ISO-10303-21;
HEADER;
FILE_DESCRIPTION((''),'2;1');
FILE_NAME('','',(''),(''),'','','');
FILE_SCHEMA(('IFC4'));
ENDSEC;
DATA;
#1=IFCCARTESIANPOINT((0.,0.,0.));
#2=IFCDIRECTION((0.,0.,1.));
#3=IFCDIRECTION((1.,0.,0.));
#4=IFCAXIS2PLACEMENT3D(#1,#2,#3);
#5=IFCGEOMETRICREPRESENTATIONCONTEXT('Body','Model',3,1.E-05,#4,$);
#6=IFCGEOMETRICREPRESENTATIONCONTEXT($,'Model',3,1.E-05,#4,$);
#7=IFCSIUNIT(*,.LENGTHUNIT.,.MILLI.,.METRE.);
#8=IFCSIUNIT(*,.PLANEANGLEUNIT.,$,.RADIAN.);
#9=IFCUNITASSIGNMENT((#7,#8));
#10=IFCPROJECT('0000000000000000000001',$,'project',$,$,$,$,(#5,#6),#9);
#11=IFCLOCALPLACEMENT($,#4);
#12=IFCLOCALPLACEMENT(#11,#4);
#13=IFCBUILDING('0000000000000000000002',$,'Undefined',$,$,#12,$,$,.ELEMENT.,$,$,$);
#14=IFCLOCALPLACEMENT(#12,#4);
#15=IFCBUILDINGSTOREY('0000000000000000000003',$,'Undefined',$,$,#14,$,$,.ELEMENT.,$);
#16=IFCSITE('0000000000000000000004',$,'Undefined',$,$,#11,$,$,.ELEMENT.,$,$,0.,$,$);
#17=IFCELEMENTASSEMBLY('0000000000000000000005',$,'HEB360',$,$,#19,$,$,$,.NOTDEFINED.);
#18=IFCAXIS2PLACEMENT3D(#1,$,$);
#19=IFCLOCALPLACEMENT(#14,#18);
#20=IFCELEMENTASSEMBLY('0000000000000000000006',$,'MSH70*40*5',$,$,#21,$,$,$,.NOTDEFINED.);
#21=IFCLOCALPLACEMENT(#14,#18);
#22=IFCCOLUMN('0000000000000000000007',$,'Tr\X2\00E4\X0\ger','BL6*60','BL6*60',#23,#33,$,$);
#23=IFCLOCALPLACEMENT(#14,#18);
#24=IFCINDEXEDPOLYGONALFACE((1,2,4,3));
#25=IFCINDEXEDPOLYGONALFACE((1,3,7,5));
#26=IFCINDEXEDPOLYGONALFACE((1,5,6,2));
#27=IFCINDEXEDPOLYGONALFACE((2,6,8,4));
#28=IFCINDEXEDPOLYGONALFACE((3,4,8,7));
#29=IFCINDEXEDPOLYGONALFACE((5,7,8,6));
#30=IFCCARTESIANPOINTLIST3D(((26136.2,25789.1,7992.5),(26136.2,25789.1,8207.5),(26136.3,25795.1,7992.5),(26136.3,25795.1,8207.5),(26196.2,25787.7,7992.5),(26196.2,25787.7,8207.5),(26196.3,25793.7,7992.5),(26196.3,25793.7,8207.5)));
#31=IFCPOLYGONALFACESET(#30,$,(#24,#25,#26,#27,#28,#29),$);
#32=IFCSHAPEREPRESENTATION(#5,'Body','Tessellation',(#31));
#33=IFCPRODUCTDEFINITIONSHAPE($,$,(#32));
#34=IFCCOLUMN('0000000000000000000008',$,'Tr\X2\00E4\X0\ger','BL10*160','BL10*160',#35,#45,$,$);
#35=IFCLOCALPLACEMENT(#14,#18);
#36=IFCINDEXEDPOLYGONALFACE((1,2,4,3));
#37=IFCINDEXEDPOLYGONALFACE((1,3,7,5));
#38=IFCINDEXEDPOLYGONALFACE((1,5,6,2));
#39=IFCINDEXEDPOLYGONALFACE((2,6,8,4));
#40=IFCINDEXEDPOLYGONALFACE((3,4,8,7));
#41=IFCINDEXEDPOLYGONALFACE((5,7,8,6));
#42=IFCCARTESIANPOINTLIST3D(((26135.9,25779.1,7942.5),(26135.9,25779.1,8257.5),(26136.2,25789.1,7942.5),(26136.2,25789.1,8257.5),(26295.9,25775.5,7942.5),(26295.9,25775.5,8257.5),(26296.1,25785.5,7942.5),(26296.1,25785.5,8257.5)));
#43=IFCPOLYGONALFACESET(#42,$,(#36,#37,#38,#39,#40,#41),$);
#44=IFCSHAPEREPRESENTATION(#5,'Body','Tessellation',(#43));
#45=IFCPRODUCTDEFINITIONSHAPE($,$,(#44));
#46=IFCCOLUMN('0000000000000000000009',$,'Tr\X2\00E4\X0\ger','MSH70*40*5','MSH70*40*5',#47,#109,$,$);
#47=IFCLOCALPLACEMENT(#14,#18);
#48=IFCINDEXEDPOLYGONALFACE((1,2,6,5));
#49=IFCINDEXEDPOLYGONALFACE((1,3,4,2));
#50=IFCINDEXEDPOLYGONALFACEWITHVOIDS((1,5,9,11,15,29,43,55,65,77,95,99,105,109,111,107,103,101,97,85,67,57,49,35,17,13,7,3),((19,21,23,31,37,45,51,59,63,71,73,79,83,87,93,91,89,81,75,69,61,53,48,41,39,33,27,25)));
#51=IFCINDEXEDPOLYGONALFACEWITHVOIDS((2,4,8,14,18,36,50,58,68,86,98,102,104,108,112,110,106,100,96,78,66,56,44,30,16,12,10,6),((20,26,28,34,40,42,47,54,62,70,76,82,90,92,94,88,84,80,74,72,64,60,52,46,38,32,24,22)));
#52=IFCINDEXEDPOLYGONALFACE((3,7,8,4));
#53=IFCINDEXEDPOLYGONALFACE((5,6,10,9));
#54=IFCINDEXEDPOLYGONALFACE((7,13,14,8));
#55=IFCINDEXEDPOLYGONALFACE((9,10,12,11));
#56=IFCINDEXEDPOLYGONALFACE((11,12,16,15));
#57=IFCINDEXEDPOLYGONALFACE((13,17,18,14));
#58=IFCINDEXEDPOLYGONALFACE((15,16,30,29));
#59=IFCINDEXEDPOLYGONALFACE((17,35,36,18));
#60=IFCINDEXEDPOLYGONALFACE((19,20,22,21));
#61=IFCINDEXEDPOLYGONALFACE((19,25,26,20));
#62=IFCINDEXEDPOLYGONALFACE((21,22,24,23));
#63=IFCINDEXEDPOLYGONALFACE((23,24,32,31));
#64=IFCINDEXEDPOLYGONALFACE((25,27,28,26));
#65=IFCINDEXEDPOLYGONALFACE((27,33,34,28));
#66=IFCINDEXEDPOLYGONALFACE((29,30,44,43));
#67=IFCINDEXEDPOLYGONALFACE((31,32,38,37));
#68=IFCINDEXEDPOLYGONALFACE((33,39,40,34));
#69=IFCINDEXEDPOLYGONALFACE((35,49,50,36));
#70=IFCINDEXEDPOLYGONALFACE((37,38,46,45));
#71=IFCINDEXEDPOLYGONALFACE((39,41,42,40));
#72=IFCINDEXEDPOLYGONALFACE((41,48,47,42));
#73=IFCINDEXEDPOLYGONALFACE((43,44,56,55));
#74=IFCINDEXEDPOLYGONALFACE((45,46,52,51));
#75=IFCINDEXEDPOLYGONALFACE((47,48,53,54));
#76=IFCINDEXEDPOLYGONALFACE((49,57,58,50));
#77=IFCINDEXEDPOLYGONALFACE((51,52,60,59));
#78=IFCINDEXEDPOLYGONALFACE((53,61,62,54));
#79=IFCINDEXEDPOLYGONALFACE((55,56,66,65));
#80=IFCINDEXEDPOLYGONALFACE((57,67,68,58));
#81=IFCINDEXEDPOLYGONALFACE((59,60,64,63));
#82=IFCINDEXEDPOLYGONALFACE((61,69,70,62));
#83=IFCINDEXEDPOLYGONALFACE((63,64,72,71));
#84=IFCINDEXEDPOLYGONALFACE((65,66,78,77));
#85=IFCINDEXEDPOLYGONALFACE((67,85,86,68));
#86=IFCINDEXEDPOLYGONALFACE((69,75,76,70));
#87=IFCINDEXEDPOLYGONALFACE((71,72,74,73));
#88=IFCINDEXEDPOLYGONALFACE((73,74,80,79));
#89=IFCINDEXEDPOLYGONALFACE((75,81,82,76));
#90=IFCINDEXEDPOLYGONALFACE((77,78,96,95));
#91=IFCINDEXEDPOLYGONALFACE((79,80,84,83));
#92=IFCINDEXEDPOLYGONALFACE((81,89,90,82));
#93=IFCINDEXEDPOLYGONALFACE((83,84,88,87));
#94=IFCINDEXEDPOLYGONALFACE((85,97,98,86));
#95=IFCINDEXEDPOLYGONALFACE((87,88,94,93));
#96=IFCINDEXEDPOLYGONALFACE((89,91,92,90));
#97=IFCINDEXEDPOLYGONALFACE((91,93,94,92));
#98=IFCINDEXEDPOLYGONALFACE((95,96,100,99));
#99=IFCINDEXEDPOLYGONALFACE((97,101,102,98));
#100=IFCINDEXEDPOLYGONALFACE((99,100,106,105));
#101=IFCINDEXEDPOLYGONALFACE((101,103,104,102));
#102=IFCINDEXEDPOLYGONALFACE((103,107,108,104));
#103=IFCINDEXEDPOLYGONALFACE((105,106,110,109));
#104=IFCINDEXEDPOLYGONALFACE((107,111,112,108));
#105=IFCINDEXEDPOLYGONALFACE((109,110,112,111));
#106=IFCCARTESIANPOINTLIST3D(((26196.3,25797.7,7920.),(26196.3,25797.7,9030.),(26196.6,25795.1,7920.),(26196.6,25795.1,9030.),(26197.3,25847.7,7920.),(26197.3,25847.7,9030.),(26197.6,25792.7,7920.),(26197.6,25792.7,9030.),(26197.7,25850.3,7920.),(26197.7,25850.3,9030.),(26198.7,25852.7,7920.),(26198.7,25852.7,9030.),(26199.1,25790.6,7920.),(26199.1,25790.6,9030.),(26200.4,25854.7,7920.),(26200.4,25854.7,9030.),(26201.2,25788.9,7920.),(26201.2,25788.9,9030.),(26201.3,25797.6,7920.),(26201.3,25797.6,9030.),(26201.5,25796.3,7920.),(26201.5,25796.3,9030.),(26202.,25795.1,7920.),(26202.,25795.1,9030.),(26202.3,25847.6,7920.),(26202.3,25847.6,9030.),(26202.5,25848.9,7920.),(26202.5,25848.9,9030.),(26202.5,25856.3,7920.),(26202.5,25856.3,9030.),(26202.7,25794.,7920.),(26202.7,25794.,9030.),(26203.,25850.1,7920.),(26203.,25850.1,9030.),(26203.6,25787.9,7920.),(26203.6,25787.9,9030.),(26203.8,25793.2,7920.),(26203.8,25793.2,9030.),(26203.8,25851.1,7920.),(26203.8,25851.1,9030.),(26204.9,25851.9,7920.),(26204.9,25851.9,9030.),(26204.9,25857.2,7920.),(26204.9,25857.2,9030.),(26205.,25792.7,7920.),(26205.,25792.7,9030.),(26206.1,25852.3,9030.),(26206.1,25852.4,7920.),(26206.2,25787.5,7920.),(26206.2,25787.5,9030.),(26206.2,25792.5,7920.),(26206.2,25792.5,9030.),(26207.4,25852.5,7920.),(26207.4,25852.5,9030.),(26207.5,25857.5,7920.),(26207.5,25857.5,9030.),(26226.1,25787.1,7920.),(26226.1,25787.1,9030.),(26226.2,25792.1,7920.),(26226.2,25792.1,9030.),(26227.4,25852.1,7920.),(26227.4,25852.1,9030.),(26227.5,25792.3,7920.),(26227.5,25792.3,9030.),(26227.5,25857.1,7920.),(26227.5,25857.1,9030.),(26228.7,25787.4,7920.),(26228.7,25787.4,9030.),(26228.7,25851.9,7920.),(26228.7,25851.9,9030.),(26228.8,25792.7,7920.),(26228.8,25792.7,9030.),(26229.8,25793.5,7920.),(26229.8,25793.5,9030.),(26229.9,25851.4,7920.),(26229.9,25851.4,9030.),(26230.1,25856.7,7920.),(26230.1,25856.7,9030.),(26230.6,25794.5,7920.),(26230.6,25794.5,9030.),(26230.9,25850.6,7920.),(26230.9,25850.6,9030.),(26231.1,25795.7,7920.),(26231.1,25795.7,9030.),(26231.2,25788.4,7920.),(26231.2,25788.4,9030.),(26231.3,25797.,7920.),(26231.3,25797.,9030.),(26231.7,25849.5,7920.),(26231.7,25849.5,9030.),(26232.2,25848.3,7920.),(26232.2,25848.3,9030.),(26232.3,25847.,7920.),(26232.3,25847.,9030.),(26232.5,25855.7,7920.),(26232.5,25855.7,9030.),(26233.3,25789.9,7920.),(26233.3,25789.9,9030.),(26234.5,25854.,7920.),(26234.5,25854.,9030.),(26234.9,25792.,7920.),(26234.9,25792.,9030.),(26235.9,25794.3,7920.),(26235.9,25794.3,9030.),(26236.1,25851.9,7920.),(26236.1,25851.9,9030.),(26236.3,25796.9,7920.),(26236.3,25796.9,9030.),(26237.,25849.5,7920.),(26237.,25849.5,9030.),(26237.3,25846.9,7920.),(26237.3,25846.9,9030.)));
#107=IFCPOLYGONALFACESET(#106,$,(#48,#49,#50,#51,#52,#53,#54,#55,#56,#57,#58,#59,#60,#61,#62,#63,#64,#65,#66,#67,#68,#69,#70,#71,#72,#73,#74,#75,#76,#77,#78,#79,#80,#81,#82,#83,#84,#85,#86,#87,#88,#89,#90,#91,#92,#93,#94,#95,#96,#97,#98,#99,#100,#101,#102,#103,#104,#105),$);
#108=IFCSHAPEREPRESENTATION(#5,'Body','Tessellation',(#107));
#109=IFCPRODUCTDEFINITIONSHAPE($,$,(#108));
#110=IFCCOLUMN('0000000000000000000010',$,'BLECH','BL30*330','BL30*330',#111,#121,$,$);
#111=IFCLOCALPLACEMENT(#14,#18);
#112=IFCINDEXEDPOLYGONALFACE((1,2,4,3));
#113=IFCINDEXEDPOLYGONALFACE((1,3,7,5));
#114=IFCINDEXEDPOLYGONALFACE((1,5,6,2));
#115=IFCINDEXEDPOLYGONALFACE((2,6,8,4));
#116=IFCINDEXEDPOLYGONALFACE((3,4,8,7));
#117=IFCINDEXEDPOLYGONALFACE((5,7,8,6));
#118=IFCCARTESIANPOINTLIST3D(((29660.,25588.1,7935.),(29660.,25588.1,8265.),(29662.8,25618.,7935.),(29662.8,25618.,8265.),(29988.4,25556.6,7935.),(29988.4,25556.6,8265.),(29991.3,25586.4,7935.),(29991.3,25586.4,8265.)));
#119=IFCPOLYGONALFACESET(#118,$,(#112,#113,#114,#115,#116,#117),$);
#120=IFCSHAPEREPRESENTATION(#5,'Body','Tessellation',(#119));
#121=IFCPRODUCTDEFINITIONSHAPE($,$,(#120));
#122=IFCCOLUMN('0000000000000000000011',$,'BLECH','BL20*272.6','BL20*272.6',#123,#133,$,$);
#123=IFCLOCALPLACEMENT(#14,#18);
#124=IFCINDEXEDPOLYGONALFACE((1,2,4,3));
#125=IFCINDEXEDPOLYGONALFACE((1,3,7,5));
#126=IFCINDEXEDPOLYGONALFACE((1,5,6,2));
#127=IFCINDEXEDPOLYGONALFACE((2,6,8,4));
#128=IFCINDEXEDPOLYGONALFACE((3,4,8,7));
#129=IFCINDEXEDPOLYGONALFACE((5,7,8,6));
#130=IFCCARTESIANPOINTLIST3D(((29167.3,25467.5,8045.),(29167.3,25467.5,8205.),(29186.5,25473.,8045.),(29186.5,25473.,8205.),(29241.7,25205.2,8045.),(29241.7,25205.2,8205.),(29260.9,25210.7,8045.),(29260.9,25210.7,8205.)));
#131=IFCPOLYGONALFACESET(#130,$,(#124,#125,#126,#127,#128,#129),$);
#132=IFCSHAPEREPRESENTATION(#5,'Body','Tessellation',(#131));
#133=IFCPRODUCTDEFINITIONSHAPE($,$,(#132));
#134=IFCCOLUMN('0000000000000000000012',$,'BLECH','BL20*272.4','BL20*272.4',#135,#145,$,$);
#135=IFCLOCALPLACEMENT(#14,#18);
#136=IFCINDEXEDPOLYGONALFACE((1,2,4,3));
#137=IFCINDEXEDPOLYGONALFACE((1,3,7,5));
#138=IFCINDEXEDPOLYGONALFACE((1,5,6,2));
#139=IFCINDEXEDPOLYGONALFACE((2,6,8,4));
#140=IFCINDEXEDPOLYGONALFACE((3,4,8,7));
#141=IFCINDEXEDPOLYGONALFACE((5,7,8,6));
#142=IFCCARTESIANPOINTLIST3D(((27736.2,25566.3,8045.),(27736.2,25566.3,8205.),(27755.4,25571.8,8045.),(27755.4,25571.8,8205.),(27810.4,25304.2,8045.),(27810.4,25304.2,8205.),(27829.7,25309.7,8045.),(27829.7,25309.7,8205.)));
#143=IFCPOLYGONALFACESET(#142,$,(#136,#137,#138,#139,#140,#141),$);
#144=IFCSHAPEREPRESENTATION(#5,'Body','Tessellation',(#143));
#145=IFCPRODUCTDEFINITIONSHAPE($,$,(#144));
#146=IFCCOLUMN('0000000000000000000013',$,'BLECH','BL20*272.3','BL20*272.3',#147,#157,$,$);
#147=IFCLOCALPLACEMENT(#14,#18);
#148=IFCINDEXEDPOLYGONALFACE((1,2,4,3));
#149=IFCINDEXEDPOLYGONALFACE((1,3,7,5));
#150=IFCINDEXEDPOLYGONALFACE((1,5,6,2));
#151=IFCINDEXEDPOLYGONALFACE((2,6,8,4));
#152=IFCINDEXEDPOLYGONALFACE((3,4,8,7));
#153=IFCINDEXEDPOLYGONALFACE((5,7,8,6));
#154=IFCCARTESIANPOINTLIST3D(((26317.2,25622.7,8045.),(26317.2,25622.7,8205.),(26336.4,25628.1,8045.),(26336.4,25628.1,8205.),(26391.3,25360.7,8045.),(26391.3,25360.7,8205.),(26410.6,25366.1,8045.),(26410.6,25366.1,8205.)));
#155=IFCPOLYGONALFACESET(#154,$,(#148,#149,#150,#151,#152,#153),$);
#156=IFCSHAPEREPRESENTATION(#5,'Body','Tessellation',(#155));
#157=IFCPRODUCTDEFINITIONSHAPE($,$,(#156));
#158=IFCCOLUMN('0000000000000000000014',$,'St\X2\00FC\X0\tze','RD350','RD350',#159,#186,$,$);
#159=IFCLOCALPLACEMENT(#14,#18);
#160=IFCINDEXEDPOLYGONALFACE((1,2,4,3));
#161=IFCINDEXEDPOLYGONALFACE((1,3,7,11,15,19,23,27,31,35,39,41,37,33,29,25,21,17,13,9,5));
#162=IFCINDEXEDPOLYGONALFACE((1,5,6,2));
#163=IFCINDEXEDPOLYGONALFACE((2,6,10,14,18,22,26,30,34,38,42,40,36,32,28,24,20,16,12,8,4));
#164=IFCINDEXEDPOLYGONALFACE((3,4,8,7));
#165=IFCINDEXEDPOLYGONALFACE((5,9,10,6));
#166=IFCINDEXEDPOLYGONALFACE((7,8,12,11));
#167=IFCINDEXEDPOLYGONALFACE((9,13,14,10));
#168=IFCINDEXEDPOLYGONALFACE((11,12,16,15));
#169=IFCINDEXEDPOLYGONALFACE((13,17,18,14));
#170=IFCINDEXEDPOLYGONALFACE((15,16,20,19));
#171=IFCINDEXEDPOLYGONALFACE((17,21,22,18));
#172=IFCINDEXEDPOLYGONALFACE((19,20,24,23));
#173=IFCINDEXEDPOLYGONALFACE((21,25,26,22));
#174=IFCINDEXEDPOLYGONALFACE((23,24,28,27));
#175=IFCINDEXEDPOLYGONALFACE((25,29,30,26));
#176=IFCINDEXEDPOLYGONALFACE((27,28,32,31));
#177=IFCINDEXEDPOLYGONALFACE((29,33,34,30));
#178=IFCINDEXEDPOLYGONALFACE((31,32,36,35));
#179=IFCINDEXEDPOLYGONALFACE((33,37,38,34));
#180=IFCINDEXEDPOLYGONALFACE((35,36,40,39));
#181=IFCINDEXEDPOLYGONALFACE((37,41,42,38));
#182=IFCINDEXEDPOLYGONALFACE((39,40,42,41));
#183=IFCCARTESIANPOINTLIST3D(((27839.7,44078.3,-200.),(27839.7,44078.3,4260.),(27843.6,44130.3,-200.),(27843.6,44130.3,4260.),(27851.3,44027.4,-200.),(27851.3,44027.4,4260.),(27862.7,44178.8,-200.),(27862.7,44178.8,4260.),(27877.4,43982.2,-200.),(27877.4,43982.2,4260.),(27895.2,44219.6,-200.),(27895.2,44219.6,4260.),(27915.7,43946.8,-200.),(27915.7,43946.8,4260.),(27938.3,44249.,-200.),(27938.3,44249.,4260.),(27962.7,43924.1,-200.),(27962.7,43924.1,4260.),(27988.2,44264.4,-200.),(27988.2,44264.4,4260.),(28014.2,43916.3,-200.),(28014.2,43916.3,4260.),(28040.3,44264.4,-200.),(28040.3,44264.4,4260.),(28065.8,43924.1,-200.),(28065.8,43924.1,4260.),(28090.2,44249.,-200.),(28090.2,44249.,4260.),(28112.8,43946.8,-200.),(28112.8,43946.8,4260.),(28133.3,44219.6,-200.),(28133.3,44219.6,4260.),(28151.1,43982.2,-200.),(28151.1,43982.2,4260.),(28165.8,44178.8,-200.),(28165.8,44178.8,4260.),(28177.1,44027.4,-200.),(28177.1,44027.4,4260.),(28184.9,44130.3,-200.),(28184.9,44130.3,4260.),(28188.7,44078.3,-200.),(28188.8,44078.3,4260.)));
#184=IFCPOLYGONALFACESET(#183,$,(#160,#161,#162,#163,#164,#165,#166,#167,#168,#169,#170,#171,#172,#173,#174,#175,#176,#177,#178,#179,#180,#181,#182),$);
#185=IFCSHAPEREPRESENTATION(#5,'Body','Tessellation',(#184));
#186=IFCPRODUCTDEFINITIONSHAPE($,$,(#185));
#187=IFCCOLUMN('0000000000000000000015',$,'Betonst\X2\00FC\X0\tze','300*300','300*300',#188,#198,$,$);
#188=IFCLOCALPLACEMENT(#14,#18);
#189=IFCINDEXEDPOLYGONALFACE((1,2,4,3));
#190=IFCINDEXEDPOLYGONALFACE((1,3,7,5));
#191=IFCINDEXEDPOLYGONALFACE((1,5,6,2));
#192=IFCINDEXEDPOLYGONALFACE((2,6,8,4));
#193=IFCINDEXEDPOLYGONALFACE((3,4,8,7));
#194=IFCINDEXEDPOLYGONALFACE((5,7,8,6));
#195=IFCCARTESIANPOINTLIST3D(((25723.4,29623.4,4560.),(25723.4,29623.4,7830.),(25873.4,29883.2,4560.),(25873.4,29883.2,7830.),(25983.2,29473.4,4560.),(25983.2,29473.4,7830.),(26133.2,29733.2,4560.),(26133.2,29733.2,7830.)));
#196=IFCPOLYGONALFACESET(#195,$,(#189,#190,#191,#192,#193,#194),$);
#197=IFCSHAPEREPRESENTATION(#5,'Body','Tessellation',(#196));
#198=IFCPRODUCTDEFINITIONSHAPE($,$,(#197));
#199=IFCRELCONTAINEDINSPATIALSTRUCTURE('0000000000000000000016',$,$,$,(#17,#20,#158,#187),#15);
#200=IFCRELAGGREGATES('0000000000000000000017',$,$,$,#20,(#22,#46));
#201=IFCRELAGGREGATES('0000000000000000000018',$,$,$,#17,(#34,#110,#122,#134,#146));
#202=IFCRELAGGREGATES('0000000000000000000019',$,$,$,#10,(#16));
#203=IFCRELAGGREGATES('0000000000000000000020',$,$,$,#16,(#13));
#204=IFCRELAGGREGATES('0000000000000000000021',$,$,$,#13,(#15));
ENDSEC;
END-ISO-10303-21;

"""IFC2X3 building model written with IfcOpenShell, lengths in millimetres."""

from ifc_helpers import new_model, si_unit, frame, origin_with_axes, origin_2d_with_axis, place, context, project, spatial, rectangle, hollow_rectangle, circle, extrude, element, aggregate, save


model = new_model("IFC2X3")

# Units and contexts
model_context_1 = context("Model", 3, precision=1e-05, world=origin_with_axes(), identifier="Body")
model_context_2 = context("Model", 3, precision=1e-05, world=origin_with_axes())
ifc_project = project(units=[si_unit("LENGTHUNIT", "METRE", prefix="MILLI"), si_unit("PLANEANGLEUNIT", "RADIAN")], contexts=[model_context_1, model_context_2])

# Site, building, storey
site_placement = place(None, origin_with_axes())
site = spatial("IfcSite", under=ifc_project, at=site_placement, Name="Undefined", CompositionType="ELEMENT", RefElevation=0.0)
building_placement = place(site_placement, origin_with_axes())
building = spatial("IfcBuilding", under=site, at=building_placement, Name="Undefined", CompositionType="ELEMENT")
storey_placement = place(building_placement, origin_with_axes())
storey = spatial("IfcBuildingStorey", under=building, at=storey_placement, Name="Undefined", CompositionType="ELEMENT")

# Element assembly
assembly_1 = element("IfcElementAssembly", 1, inside=storey, Name="HEB360", PredefinedType="NOTDEFINED")

# Element assembly, column
assembly_2 = element("IfcElementAssembly", 2, inside=storey, Name="MSH70*40*5", PredefinedType="NOTDEFINED")
column_1_placement = place(storey_placement, frame((26166.2, 25791.4, 7992.5), z_axis=(0.0, 0.0, 1.0), x_axis=(1.0, 0.0, 0.0)))
column_1 = element("IfcColumn", 3, at=column_1_placement, Name="Träger", Description="BL6*60", ObjectType="BL6*60", context=model_context_1, shape_type="SweptSolid", body=[
    extrude(rectangle(XDim=6.0, YDim=60.0, at=origin_2d_with_axis()), frame((0.0, 0.0, 215.0), z_axis=(0.0, 0.0, -1.0), x_axis=(0.022687, 0.999743, 0.0)), (0.0, 0.0, 1.0), 215.0),
])

# Columns
column_2_placement = place(storey_placement, frame((26216.0, 25782.3, 7942.5), z_axis=(0.0, 0.0, 1.0), x_axis=(1.0, 0.0, 0.0)))
column_2 = element("IfcColumn", 4, at=column_2_placement, Name="Träger", Description="BL10*160", ObjectType="BL10*160", context=model_context_1, shape_type="SweptSolid", body=[
    extrude(rectangle(XDim=10.0, YDim=160.0, at=origin_2d_with_axis()), frame((0.0, 0.0, 315.0), z_axis=(0.0, 0.0, -1.0), x_axis=(0.022687, 0.999743, 0.0)), (0.0, 0.0, 1.0), 315.0),
])
column_3_placement = place(storey_placement, frame((26216.8, 25822.3, 7920.0), z_axis=(0.0, 0.0, 1.0), x_axis=(1.0, 0.0, 0.0)))
column_3 = element("IfcColumn", 5, at=column_3_placement, Name="Träger", Description="MSH70*40*5", ObjectType="MSH70*40*5", context=model_context_1, shape_type="SweptSolid", body=[
    extrude(hollow_rectangle(XDim=40.0, YDim=70.0, WallThickness=5.0, InnerFilletRadius=5.0, OuterFilletRadius=10.0, at=origin_2d_with_axis()), frame((0.0, 0.0, 1110.0), z_axis=(0.0, 0.0, -1.0), x_axis=(0.999816, -0.019197, 0.000005)), (0.0, 0.0, 1.0), 1110.0),
])
aggregate(assembly_2, [column_1, column_3])
column_4_placement = place(storey_placement, frame((29825.6, 25587.3, 7935.0), z_axis=(0.0, 0.0, 1.0), x_axis=(1.0, 0.0, 0.0)))
column_4 = element("IfcColumn", 6, at=column_4_placement, Name="BLECH", Description="BL30*330", ObjectType="BL30*330", context=model_context_1, shape_type="SweptSolid", body=[
    extrude(rectangle(XDim=30.0, YDim=330.0, at=origin_2d_with_axis()), frame((0.0, 0.0, 330.0), z_axis=(0.0, 0.0, -1.0), x_axis=(0.095654, 0.995415, 0.0)), (0.0, 0.0, 1.0), 330.0),
])
column_5_placement = place(storey_placement, frame((29214.1, 25339.1, 8045.0), z_axis=(0.0, 0.0, 1.0), x_axis=(1.0, 0.0, 0.0)))
column_5 = element("IfcColumn", 7, at=column_5_placement, Name="BLECH", Description="BL20*272.6", ObjectType="BL20*272.6", context=model_context_1, shape_type="SweptSolid", body=[
    extrude(rectangle(XDim=20.0, YDim=272.6, at=origin_2d_with_axis()), frame((0.0, 0.0, 160.0), z_axis=(0.0, 0.0, -1.0), x_axis=(-0.96203, -0.272943, 0.0)), (0.0, 0.0, 1.0), 160.0),
])
column_6_placement = place(storey_placement, frame((27782.9, 25438.0, 8045.0), z_axis=(0.0, 0.0, 1.0), x_axis=(1.0, 0.0, 0.0)))
column_6 = element("IfcColumn", 8, at=column_6_placement, Name="BLECH", Description="BL20*272.4", ObjectType="BL20*272.4", context=model_context_1, shape_type="SweptSolid", body=[
    extrude(rectangle(XDim=20.0, YDim=272.4, at=origin_2d_with_axis()), frame((0.0, 0.0, 160.0), z_axis=(0.0, 0.0, -1.0), x_axis=(-0.96217, -0.272448, 0.0)), (0.0, 0.0, 1.0), 160.0),
])
column_7_placement = place(storey_placement, frame((26363.9, 25494.4, 8045.0), z_axis=(0.0, 0.0, 1.0), x_axis=(1.0, 0.0, 0.0)))
column_7 = element("IfcColumn", 9, at=column_7_placement, Name="BLECH", Description="BL20*272.3", ObjectType="BL20*272.3", context=model_context_1, shape_type="SweptSolid", body=[
    extrude(rectangle(XDim=20.0, YDim=272.3, at=origin_2d_with_axis()), frame((0.0, 0.0, 160.0), z_axis=(0.0, 0.0, -1.0), x_axis=(-0.96217, -0.272448, 0.0)), (0.0, 0.0, 1.0), 160.0),
])
aggregate(assembly_1, [column_2, column_4, column_5, column_6, column_7])
column_8_placement = place(storey_placement, frame((28014.2, 44091.3, -200.0), z_axis=(0.0, 0.0, 1.0), x_axis=(1.0, 0.0, 0.0)))
element("IfcColumn", 10, at=column_8_placement, inside=storey, Name="Stütze", Description="RD350", ObjectType="RD350", context=model_context_1, shape_type="SweptSolid", body=[
    extrude(circle(Radius=175.0, at=origin_2d_with_axis()), frame((0.0, 0.0, 4460.0), z_axis=(0.0, 0.0, -1.0), x_axis=(-0.866025, 0.500001, 0.0)), (0.0, 0.0, 1.0), 4460.0),
])

# Column
column_9_placement = place(storey_placement, frame((25928.3, 29678.3, 4560.0), z_axis=(0.0, 0.0, 1.0), x_axis=(1.0, 0.0, 0.0)))
element("IfcColumn", 11, at=column_9_placement, inside=storey, Name="Betonstütze", Description="300*300", ObjectType="300*300", context=model_context_1, shape_type="SweptSolid", body=[
    extrude(rectangle(XDim=300.0, YDim=300.0, at=origin_2d_with_axis()), frame((0.0, 0.0, 3270.0), z_axis=(0.0, 0.0, -1.0), x_axis=(0.866025, -0.5, 0.0)), (0.0, 0.0, 1.0), 3270.0),
])

save(model, "model.ifc")
